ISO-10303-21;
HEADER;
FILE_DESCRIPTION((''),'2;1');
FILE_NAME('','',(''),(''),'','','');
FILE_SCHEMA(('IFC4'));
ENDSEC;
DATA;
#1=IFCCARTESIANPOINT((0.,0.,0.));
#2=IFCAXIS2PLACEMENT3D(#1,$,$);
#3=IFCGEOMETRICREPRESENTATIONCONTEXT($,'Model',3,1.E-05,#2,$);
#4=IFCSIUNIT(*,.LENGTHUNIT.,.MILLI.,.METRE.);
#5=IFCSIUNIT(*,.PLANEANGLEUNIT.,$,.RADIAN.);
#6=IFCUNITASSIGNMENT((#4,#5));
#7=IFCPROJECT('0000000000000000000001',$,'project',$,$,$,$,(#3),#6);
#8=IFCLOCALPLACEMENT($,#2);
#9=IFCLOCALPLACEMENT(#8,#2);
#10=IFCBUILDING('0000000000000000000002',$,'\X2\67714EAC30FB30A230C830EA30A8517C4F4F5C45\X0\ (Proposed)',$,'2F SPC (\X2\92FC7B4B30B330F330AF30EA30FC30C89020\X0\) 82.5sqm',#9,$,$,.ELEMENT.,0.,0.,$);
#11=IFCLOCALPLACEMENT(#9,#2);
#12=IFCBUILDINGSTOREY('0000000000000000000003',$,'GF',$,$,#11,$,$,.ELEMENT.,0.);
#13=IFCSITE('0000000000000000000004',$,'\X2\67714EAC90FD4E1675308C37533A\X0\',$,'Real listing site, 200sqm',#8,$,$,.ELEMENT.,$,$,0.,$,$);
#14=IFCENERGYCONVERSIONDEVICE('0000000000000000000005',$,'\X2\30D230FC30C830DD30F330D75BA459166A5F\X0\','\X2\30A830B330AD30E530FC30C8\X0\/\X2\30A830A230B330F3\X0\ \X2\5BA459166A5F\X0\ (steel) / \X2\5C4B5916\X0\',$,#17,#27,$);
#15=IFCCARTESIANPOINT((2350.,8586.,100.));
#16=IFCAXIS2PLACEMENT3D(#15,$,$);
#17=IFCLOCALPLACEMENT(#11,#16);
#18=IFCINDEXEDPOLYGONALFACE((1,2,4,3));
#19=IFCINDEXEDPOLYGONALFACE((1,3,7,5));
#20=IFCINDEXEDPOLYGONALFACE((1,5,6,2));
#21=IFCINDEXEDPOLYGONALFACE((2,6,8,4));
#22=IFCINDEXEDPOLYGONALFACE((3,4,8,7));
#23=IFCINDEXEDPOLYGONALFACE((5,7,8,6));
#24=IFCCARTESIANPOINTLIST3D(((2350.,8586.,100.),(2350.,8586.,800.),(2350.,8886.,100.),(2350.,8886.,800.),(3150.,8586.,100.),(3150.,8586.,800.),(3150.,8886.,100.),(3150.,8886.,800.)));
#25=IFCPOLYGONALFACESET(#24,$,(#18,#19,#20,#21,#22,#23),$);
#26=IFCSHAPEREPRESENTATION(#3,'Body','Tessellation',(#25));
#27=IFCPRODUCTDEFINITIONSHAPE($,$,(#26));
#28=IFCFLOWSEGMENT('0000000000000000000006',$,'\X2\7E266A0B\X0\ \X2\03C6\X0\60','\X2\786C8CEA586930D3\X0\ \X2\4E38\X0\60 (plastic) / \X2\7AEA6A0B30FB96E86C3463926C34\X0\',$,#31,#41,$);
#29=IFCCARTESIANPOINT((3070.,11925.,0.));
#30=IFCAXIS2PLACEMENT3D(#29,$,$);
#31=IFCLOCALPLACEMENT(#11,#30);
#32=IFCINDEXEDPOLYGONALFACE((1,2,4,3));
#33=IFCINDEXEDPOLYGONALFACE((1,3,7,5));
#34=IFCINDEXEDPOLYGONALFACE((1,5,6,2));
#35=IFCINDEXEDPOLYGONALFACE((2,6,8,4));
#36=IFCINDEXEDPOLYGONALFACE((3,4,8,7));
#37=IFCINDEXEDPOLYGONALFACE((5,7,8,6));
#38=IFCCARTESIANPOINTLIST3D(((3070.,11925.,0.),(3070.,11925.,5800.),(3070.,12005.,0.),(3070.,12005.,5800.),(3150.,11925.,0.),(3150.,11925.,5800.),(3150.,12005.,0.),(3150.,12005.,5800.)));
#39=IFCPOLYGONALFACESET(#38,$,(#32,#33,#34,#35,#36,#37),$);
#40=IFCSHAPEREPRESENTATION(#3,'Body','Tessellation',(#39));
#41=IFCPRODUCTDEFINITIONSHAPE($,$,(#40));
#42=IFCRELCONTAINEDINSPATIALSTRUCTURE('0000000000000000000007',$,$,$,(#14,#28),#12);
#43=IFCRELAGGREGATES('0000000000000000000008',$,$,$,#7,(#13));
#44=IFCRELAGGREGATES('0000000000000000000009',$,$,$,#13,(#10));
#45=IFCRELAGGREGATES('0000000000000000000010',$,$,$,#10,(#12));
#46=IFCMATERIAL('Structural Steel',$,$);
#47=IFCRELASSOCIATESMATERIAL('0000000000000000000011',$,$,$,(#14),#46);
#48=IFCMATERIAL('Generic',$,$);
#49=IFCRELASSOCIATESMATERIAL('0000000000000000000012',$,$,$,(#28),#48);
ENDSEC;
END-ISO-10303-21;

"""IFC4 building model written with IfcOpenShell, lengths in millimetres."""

from ifc_helpers import new_model, si_unit, frame, frame_2d, origin, place, context, project, spatial, rectangle, extrude, material, element, save


model = new_model("IFC4")

# Units and contexts
model_context = context("Model", 3, precision=1e-05, world=origin())
ifc_project = project(units=[si_unit("LENGTHUNIT", "METRE", prefix="MILLI"), si_unit("PLANEANGLEUNIT", "RADIAN")], contexts=[model_context])

# Site, building, storey
site_placement = place(None, origin())
site = spatial("IfcSite", under=ifc_project, at=site_placement, Name="東京都世田谷区", ObjectType="Real listing site, 200sqm", CompositionType="ELEMENT", RefElevation=0.0)
building_placement = place(site_placement, origin())
building = spatial("IfcBuilding", under=site, at=building_placement, Name="東京・アトリエ兼住居 (Proposed)", ObjectType="2F SPC (鋼筋コンクリート造) 82.5sqm", CompositionType="ELEMENT", ElevationOfRefHeight=0.0, ElevationOfTerrain=0.0)
storey_placement = place(building_placement, origin())
storey = spatial("IfcBuildingStorey", under=building, at=storey_placement, Name="GF", CompositionType="ELEMENT", Elevation=0.0)

# Shared definitions
ifc_material_1 = material(Name="Generic")

# Energy conversion device
ifc_material_2 = material(Name="Structural Steel")
energy_conversion_device_placement = place(storey_placement, frame((2350.0, 8586.0, 100.0)))
element("IfcEnergyConversionDevice", 1, at=energy_conversion_device_placement, inside=storey, material=ifc_material_2, Name="ヒートポンプ室外機", Description="エコキュート/エアコン 室外機 (steel) / 屋外", context=model_context, shape_type="SweptSolid", body=[
    extrude(rectangle(XDim=800.0, YDim=300.0, at=frame_2d((400.0, 150.0))), frame((2350.0, 8586.0, 100.0)), (0.0, 0.0, 1.0), 700.0),
])

# Flow segment
flow_segment_placement = place(storey_placement, frame((3070.0, 11925.0, 0.0)))
element("IfcFlowSegment", 2, at=flow_segment_placement, inside=storey, material=ifc_material_1, Name="縦樋 φ60", Description="硬質塩ビ 丸60 (plastic) / 竪樋・雨水排水", context=model_context, shape_type="SweptSolid", body=[
    extrude(rectangle(XDim=80.0, YDim=80.0, at=frame_2d((40.0, 40.0))), frame((3070.0, 11925.0, 0.0)), (0.0, 0.0, 1.0), 5800.0),
])

save(model, "model.ifc")
